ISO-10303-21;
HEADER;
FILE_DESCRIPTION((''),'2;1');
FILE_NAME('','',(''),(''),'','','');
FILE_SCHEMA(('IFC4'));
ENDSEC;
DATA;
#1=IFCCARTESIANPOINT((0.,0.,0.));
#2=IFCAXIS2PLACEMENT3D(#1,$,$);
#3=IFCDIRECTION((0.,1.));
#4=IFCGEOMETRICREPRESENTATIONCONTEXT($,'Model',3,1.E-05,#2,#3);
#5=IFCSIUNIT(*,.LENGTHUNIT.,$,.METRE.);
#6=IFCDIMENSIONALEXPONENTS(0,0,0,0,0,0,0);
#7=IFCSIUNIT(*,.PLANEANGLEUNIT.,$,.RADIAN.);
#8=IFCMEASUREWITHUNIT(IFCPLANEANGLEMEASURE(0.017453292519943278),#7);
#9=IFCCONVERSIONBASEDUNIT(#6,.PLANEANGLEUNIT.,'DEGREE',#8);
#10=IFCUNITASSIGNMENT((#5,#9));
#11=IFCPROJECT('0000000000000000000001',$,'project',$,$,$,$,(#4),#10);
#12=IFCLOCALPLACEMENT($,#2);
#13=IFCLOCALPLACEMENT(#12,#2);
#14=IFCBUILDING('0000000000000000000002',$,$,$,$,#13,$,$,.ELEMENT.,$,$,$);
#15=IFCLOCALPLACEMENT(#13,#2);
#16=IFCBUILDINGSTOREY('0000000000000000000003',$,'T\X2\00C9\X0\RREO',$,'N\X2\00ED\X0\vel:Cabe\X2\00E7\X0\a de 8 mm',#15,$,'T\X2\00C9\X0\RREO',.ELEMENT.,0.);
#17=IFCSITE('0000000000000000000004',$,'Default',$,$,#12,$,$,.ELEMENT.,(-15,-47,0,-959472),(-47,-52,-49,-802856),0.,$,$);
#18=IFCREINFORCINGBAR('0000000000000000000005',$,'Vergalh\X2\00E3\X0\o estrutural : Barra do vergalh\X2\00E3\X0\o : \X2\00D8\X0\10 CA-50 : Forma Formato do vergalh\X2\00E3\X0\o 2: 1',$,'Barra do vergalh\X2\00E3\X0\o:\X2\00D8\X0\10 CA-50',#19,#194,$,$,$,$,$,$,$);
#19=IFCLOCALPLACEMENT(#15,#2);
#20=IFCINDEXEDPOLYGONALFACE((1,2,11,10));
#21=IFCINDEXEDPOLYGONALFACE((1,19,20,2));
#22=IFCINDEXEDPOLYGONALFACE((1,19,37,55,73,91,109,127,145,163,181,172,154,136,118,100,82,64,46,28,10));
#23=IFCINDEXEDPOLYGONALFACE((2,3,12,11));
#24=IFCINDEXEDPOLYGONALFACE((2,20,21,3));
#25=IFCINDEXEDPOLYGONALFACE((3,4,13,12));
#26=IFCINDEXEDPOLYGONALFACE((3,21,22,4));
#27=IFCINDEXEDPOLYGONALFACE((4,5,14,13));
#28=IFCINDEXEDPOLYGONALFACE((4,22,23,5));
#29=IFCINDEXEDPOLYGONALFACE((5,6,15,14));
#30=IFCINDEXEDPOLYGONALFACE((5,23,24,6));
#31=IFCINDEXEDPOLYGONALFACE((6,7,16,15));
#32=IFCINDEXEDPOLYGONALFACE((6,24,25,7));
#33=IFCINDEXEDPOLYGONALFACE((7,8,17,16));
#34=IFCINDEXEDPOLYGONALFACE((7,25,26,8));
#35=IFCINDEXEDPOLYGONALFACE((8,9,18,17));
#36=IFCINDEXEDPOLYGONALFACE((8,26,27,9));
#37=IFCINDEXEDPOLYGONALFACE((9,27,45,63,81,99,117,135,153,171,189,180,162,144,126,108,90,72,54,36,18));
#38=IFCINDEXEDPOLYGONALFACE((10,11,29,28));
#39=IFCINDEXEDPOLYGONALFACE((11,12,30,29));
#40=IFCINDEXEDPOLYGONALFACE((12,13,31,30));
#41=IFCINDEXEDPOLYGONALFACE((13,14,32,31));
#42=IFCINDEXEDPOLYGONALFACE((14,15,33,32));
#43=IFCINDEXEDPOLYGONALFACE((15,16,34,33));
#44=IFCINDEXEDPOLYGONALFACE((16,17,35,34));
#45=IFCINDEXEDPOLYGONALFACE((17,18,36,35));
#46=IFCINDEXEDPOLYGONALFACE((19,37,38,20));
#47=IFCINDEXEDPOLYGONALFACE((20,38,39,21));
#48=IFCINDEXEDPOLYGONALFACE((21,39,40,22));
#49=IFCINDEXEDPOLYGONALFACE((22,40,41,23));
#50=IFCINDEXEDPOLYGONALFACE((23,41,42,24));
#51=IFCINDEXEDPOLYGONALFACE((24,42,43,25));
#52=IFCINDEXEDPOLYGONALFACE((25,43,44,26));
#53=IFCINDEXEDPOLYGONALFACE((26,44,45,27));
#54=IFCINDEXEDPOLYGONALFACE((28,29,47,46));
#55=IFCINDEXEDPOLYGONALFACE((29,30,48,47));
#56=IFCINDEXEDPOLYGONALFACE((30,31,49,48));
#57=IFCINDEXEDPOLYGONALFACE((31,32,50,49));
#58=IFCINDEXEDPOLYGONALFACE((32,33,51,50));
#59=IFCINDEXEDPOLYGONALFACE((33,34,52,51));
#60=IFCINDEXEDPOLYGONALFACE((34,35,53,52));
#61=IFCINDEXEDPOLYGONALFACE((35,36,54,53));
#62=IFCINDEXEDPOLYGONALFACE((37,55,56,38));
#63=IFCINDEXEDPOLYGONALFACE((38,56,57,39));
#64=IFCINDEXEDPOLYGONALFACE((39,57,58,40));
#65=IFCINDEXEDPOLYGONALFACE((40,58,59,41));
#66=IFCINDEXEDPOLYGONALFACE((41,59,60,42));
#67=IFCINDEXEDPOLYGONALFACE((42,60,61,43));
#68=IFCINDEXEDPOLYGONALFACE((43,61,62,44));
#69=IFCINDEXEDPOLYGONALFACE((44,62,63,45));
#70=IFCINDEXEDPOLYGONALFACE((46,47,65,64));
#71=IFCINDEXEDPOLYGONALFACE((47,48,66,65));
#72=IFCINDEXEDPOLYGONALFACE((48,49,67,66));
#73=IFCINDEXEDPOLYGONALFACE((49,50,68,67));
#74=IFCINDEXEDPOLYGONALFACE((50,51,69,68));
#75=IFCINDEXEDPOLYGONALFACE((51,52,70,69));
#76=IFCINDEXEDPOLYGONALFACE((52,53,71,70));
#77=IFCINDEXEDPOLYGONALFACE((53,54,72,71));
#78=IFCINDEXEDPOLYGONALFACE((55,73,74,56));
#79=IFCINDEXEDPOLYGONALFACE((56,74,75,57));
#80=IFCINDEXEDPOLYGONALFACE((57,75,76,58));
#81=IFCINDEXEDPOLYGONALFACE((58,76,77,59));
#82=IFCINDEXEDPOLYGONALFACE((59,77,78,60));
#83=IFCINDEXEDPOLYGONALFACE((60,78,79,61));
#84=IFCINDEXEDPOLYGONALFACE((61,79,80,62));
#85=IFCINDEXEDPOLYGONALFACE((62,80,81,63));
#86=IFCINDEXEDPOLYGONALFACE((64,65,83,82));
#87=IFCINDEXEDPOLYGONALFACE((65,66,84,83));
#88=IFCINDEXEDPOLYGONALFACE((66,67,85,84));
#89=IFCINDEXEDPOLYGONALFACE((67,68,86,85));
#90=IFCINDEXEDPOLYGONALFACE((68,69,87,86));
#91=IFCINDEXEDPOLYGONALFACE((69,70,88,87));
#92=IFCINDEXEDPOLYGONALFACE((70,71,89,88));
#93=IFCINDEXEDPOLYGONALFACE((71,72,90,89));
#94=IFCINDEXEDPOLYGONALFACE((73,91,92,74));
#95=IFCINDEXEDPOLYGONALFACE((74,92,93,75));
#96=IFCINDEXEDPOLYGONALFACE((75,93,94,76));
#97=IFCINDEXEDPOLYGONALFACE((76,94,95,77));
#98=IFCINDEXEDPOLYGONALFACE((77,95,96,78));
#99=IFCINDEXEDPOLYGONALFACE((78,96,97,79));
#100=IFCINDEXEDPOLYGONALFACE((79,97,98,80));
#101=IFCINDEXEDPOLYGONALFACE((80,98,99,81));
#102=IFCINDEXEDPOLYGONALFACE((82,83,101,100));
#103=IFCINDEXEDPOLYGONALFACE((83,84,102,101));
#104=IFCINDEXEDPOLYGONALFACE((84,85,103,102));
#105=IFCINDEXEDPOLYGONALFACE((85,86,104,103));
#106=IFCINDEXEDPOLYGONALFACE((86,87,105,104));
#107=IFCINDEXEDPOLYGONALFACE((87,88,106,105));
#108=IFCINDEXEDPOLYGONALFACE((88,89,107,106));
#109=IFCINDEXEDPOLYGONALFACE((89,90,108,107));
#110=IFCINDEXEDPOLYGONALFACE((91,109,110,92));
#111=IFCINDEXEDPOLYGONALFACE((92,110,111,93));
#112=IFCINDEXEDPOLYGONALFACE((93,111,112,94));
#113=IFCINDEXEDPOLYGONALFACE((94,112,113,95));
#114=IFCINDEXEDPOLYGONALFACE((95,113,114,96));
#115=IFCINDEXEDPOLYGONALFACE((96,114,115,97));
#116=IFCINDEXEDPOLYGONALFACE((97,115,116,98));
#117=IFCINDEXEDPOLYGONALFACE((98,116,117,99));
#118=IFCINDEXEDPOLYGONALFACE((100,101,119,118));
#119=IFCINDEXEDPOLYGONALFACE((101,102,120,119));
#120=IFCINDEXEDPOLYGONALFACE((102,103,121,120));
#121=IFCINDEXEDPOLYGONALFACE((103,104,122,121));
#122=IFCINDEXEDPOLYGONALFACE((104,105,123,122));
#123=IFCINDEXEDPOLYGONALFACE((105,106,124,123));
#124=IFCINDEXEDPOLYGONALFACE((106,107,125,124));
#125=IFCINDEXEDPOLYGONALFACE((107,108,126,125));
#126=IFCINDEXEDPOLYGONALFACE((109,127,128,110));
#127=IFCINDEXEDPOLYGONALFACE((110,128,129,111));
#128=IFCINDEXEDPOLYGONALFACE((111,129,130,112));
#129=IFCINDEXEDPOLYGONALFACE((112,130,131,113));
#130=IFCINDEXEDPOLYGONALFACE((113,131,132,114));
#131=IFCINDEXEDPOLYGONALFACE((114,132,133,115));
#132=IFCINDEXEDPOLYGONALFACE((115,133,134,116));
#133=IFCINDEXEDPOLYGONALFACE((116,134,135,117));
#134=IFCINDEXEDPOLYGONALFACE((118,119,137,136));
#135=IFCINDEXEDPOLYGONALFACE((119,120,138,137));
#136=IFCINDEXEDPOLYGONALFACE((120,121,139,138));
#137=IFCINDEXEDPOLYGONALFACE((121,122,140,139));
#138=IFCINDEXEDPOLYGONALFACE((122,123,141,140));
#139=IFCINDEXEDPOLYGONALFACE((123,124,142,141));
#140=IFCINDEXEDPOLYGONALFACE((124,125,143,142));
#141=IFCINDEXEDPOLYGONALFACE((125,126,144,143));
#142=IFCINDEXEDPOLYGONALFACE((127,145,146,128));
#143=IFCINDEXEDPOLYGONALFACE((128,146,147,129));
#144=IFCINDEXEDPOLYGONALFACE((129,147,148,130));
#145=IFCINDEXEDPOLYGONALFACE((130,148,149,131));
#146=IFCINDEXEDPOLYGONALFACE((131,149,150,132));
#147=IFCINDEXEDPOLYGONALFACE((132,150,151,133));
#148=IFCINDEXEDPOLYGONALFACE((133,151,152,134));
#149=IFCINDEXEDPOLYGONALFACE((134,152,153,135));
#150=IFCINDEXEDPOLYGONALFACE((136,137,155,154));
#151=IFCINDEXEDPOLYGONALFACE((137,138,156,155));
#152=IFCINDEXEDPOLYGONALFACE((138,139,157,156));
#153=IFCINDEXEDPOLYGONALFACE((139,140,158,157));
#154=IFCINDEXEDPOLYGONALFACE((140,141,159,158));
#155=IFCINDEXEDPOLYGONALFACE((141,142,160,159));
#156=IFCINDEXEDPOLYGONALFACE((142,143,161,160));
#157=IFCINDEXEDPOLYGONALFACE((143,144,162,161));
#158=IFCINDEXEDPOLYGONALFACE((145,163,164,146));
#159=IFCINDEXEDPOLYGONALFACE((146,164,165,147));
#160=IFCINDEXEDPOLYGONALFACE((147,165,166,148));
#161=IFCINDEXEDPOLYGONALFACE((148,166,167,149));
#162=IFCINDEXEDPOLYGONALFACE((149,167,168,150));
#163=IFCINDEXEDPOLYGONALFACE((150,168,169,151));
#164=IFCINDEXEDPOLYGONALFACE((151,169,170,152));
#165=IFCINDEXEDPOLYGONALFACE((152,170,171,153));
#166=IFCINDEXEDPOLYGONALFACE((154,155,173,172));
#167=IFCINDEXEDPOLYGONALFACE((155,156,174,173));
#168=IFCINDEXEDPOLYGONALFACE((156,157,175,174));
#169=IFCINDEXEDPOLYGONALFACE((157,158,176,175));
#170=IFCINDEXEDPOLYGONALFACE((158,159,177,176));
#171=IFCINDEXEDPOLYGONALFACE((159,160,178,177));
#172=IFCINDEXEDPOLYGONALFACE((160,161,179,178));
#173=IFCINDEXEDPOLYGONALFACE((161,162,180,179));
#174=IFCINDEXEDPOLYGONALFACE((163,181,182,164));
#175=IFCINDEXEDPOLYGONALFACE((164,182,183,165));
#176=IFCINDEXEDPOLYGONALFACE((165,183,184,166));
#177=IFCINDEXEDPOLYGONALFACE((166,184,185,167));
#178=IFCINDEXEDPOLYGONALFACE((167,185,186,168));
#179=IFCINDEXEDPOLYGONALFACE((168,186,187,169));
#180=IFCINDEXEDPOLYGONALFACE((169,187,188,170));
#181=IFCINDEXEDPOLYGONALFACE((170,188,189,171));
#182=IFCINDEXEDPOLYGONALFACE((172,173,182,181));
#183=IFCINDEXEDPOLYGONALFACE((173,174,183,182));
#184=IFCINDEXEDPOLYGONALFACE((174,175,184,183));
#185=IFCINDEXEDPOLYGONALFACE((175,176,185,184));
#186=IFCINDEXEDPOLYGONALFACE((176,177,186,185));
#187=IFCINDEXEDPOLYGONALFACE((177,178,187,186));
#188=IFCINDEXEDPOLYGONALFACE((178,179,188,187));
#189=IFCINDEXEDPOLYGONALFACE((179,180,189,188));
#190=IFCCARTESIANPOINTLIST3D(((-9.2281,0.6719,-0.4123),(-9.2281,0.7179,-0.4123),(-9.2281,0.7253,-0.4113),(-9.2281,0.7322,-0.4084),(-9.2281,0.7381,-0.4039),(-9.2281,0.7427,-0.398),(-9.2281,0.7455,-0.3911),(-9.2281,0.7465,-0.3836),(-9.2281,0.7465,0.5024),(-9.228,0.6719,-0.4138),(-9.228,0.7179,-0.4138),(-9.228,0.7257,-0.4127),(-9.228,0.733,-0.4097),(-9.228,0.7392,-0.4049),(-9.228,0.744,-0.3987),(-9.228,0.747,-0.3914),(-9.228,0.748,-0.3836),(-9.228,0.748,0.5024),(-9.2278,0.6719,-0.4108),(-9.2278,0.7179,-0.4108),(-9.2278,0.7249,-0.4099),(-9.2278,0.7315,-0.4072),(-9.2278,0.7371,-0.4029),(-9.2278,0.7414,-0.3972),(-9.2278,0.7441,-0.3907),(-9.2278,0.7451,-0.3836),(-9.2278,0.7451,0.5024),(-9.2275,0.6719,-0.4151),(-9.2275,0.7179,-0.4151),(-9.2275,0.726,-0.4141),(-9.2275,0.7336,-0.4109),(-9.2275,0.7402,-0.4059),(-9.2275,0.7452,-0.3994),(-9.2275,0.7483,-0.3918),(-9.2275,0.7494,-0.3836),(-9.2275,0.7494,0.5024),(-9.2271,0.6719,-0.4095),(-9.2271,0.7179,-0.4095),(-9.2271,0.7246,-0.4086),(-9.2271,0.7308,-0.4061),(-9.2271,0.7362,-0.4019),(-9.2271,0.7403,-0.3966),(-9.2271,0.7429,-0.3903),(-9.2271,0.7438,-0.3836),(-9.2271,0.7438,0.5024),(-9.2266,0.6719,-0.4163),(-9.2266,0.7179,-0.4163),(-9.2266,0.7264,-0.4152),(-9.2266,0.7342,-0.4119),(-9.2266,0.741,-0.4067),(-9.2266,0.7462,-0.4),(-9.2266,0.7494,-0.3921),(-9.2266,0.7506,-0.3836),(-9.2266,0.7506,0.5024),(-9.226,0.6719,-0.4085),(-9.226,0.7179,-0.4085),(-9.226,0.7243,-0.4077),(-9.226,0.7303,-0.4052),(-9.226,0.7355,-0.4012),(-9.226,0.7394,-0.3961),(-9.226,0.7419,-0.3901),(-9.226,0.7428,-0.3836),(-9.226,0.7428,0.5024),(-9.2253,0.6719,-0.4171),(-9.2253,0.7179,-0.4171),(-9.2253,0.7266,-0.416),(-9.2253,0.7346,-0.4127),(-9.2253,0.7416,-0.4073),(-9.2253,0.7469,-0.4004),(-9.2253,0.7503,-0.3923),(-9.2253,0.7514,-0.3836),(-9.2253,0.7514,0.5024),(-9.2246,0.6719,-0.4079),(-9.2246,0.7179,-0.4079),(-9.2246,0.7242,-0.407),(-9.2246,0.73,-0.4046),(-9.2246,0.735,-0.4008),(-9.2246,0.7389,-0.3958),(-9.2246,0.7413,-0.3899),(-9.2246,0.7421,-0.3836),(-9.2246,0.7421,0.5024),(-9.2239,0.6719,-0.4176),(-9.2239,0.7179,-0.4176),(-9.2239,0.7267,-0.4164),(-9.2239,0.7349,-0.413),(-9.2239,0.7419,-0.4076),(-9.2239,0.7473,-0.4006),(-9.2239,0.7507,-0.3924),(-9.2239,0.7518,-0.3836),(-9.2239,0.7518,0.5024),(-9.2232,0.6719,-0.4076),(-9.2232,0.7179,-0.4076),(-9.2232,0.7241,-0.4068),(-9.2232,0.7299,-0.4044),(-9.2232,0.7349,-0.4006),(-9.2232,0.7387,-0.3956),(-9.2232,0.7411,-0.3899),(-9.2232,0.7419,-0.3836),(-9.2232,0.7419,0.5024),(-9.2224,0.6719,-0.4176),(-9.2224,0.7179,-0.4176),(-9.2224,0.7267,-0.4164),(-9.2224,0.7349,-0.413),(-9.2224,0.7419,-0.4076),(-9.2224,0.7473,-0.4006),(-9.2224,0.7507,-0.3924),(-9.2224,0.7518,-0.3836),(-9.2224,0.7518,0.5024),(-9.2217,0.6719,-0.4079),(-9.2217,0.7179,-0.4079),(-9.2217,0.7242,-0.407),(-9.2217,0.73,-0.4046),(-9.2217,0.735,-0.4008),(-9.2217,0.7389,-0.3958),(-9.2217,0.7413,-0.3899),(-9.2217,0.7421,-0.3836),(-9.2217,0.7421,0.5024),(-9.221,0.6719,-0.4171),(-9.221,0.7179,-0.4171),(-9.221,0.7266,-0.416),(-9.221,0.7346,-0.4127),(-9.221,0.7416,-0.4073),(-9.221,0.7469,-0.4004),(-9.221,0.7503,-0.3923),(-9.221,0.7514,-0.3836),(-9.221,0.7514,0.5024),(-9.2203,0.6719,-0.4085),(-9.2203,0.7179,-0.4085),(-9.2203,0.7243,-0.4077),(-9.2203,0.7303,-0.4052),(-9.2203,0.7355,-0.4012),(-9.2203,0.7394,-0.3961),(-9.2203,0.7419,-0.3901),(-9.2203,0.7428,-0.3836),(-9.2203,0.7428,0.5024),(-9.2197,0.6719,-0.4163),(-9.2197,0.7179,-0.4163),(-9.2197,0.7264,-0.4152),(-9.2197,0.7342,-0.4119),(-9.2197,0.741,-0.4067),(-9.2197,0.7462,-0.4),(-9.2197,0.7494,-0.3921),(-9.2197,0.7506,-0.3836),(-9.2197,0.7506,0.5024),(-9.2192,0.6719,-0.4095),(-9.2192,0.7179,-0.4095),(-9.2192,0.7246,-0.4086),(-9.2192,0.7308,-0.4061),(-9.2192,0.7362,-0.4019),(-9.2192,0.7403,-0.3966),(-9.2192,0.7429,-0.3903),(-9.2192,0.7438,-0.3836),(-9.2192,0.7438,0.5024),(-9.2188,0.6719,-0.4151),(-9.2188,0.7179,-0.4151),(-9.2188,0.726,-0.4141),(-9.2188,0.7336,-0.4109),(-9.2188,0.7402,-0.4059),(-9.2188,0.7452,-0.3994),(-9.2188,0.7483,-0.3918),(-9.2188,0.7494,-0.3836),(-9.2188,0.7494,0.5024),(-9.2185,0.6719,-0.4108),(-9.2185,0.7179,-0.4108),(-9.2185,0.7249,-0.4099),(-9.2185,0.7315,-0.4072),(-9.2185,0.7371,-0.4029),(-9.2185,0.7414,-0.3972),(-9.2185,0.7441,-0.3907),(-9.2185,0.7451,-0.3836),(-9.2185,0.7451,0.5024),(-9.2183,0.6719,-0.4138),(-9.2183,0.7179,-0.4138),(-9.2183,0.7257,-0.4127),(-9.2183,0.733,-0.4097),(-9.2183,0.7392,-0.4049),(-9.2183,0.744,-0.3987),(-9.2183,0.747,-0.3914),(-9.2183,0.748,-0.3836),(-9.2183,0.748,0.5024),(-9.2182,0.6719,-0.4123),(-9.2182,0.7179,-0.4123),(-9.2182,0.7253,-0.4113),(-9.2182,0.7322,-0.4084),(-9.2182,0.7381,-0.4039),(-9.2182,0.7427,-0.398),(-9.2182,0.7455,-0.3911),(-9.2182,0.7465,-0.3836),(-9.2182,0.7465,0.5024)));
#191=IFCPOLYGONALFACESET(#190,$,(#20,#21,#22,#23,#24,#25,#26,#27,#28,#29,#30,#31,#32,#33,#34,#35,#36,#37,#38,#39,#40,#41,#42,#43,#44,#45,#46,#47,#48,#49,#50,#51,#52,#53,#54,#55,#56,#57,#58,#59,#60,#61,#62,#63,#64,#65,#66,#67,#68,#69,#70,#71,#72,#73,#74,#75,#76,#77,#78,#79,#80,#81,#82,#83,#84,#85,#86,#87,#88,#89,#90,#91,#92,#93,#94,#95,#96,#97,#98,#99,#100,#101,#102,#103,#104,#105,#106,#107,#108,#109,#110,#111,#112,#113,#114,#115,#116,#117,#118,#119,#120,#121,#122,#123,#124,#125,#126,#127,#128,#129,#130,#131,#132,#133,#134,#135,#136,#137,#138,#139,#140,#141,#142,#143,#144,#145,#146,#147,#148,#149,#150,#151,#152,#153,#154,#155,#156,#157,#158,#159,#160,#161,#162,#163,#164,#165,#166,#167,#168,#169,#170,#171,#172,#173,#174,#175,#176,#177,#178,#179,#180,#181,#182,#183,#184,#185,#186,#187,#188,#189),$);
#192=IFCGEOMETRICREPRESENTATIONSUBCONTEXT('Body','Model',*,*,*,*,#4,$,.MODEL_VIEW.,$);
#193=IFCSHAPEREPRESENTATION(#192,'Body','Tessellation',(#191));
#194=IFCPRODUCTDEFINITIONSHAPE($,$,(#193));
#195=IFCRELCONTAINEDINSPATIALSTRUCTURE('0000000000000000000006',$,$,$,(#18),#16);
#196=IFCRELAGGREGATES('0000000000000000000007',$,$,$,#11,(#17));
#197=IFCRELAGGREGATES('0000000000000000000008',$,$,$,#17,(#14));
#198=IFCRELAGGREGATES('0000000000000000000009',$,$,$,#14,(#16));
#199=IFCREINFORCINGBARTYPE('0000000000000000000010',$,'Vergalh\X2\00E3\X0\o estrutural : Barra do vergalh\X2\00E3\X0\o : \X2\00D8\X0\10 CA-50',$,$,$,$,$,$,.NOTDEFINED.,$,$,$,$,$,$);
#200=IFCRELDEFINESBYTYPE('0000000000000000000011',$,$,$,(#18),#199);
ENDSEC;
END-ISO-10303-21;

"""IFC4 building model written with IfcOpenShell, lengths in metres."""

from ifc_helpers import new_model, entity, si_unit, converted_unit, direction, origin, place, context, subcontext, project, spatial, type_object, element, save


model = new_model("IFC4")

# Units and contexts
model_context = context("Model", 3, precision=1e-05, world=origin(), true_north=direction((0.0, 1.0)))
body_context = subcontext(model_context, "Body", "Model", "MODEL_VIEW")
ifc_project = project(units=[si_unit("LENGTHUNIT", "METRE"), converted_unit("PLANEANGLEUNIT", "DEGREE", entity("IfcPlaneAngleMeasure", 0.017453292519943278), si_unit("PLANEANGLEUNIT", "RADIAN"), dimensions=[0, 0, 0, 0, 0, 0, 0])], contexts=[model_context])

# Site, building, storey
site_placement = place(None, origin())
site = spatial("IfcSite", under=ifc_project, at=site_placement, Name="Default", CompositionType="ELEMENT", RefLatitude=(-15, -47, 0, -959472), RefLongitude=(-47, -52, -49, -802856), RefElevation=0.0)
building_placement = place(site_placement, origin())
building = spatial("IfcBuilding", under=site, at=building_placement, CompositionType="ELEMENT")
storey_placement = place(building_placement, origin())
storey = spatial("IfcBuildingStorey", under=building, at=storey_placement, Name="TÉRREO", ObjectType="Nível:Cabeça de 8 mm", LongName="TÉRREO", CompositionType="ELEMENT", Elevation=0.0)

# Reinforcing bar
reinforcing_bar_type_1 = type_object("IfcReinforcingBarType", Name="Vergalhão estrutural : Barra do vergalhão : Ø10 CA-50", PredefinedType="NOTDEFINED")
reinforcing_bar_1_placement = place(storey_placement, origin())
element("IfcReinforcingBar", 1, at=reinforcing_bar_1_placement, inside=storey, type_object=reinforcing_bar_type_1, Name="Vergalhão estrutural : Barra do vergalhão : Ø10 CA-50 : Forma Formato do vergalhão 2: 1", ObjectType="Barra do vergalhão:Ø10 CA-50", context=body_context, shape_type="AdvancedSweptSolid", body=[
    entity("IfcSweptDiskSolid", entity("IfcIndexedPolyCurve", entity("IfcCartesianPointList3D", [[-9.2232, 0.6719, -0.4126], [-9.2232, 0.7179, -0.4126], [-9.2232, 0.7384, -0.4042], [-9.2232, 0.7469, -0.3836], [-9.2232, 0.7469, 0.5024]]), [entity("IfcLineIndex", [1, 2]), entity("IfcArcIndex", [2, 3, 4]), entity("IfcLineIndex", [4, 5])], False), 0.005, None, 0.0, 92.0),
])

save(model, "model.ifc")
